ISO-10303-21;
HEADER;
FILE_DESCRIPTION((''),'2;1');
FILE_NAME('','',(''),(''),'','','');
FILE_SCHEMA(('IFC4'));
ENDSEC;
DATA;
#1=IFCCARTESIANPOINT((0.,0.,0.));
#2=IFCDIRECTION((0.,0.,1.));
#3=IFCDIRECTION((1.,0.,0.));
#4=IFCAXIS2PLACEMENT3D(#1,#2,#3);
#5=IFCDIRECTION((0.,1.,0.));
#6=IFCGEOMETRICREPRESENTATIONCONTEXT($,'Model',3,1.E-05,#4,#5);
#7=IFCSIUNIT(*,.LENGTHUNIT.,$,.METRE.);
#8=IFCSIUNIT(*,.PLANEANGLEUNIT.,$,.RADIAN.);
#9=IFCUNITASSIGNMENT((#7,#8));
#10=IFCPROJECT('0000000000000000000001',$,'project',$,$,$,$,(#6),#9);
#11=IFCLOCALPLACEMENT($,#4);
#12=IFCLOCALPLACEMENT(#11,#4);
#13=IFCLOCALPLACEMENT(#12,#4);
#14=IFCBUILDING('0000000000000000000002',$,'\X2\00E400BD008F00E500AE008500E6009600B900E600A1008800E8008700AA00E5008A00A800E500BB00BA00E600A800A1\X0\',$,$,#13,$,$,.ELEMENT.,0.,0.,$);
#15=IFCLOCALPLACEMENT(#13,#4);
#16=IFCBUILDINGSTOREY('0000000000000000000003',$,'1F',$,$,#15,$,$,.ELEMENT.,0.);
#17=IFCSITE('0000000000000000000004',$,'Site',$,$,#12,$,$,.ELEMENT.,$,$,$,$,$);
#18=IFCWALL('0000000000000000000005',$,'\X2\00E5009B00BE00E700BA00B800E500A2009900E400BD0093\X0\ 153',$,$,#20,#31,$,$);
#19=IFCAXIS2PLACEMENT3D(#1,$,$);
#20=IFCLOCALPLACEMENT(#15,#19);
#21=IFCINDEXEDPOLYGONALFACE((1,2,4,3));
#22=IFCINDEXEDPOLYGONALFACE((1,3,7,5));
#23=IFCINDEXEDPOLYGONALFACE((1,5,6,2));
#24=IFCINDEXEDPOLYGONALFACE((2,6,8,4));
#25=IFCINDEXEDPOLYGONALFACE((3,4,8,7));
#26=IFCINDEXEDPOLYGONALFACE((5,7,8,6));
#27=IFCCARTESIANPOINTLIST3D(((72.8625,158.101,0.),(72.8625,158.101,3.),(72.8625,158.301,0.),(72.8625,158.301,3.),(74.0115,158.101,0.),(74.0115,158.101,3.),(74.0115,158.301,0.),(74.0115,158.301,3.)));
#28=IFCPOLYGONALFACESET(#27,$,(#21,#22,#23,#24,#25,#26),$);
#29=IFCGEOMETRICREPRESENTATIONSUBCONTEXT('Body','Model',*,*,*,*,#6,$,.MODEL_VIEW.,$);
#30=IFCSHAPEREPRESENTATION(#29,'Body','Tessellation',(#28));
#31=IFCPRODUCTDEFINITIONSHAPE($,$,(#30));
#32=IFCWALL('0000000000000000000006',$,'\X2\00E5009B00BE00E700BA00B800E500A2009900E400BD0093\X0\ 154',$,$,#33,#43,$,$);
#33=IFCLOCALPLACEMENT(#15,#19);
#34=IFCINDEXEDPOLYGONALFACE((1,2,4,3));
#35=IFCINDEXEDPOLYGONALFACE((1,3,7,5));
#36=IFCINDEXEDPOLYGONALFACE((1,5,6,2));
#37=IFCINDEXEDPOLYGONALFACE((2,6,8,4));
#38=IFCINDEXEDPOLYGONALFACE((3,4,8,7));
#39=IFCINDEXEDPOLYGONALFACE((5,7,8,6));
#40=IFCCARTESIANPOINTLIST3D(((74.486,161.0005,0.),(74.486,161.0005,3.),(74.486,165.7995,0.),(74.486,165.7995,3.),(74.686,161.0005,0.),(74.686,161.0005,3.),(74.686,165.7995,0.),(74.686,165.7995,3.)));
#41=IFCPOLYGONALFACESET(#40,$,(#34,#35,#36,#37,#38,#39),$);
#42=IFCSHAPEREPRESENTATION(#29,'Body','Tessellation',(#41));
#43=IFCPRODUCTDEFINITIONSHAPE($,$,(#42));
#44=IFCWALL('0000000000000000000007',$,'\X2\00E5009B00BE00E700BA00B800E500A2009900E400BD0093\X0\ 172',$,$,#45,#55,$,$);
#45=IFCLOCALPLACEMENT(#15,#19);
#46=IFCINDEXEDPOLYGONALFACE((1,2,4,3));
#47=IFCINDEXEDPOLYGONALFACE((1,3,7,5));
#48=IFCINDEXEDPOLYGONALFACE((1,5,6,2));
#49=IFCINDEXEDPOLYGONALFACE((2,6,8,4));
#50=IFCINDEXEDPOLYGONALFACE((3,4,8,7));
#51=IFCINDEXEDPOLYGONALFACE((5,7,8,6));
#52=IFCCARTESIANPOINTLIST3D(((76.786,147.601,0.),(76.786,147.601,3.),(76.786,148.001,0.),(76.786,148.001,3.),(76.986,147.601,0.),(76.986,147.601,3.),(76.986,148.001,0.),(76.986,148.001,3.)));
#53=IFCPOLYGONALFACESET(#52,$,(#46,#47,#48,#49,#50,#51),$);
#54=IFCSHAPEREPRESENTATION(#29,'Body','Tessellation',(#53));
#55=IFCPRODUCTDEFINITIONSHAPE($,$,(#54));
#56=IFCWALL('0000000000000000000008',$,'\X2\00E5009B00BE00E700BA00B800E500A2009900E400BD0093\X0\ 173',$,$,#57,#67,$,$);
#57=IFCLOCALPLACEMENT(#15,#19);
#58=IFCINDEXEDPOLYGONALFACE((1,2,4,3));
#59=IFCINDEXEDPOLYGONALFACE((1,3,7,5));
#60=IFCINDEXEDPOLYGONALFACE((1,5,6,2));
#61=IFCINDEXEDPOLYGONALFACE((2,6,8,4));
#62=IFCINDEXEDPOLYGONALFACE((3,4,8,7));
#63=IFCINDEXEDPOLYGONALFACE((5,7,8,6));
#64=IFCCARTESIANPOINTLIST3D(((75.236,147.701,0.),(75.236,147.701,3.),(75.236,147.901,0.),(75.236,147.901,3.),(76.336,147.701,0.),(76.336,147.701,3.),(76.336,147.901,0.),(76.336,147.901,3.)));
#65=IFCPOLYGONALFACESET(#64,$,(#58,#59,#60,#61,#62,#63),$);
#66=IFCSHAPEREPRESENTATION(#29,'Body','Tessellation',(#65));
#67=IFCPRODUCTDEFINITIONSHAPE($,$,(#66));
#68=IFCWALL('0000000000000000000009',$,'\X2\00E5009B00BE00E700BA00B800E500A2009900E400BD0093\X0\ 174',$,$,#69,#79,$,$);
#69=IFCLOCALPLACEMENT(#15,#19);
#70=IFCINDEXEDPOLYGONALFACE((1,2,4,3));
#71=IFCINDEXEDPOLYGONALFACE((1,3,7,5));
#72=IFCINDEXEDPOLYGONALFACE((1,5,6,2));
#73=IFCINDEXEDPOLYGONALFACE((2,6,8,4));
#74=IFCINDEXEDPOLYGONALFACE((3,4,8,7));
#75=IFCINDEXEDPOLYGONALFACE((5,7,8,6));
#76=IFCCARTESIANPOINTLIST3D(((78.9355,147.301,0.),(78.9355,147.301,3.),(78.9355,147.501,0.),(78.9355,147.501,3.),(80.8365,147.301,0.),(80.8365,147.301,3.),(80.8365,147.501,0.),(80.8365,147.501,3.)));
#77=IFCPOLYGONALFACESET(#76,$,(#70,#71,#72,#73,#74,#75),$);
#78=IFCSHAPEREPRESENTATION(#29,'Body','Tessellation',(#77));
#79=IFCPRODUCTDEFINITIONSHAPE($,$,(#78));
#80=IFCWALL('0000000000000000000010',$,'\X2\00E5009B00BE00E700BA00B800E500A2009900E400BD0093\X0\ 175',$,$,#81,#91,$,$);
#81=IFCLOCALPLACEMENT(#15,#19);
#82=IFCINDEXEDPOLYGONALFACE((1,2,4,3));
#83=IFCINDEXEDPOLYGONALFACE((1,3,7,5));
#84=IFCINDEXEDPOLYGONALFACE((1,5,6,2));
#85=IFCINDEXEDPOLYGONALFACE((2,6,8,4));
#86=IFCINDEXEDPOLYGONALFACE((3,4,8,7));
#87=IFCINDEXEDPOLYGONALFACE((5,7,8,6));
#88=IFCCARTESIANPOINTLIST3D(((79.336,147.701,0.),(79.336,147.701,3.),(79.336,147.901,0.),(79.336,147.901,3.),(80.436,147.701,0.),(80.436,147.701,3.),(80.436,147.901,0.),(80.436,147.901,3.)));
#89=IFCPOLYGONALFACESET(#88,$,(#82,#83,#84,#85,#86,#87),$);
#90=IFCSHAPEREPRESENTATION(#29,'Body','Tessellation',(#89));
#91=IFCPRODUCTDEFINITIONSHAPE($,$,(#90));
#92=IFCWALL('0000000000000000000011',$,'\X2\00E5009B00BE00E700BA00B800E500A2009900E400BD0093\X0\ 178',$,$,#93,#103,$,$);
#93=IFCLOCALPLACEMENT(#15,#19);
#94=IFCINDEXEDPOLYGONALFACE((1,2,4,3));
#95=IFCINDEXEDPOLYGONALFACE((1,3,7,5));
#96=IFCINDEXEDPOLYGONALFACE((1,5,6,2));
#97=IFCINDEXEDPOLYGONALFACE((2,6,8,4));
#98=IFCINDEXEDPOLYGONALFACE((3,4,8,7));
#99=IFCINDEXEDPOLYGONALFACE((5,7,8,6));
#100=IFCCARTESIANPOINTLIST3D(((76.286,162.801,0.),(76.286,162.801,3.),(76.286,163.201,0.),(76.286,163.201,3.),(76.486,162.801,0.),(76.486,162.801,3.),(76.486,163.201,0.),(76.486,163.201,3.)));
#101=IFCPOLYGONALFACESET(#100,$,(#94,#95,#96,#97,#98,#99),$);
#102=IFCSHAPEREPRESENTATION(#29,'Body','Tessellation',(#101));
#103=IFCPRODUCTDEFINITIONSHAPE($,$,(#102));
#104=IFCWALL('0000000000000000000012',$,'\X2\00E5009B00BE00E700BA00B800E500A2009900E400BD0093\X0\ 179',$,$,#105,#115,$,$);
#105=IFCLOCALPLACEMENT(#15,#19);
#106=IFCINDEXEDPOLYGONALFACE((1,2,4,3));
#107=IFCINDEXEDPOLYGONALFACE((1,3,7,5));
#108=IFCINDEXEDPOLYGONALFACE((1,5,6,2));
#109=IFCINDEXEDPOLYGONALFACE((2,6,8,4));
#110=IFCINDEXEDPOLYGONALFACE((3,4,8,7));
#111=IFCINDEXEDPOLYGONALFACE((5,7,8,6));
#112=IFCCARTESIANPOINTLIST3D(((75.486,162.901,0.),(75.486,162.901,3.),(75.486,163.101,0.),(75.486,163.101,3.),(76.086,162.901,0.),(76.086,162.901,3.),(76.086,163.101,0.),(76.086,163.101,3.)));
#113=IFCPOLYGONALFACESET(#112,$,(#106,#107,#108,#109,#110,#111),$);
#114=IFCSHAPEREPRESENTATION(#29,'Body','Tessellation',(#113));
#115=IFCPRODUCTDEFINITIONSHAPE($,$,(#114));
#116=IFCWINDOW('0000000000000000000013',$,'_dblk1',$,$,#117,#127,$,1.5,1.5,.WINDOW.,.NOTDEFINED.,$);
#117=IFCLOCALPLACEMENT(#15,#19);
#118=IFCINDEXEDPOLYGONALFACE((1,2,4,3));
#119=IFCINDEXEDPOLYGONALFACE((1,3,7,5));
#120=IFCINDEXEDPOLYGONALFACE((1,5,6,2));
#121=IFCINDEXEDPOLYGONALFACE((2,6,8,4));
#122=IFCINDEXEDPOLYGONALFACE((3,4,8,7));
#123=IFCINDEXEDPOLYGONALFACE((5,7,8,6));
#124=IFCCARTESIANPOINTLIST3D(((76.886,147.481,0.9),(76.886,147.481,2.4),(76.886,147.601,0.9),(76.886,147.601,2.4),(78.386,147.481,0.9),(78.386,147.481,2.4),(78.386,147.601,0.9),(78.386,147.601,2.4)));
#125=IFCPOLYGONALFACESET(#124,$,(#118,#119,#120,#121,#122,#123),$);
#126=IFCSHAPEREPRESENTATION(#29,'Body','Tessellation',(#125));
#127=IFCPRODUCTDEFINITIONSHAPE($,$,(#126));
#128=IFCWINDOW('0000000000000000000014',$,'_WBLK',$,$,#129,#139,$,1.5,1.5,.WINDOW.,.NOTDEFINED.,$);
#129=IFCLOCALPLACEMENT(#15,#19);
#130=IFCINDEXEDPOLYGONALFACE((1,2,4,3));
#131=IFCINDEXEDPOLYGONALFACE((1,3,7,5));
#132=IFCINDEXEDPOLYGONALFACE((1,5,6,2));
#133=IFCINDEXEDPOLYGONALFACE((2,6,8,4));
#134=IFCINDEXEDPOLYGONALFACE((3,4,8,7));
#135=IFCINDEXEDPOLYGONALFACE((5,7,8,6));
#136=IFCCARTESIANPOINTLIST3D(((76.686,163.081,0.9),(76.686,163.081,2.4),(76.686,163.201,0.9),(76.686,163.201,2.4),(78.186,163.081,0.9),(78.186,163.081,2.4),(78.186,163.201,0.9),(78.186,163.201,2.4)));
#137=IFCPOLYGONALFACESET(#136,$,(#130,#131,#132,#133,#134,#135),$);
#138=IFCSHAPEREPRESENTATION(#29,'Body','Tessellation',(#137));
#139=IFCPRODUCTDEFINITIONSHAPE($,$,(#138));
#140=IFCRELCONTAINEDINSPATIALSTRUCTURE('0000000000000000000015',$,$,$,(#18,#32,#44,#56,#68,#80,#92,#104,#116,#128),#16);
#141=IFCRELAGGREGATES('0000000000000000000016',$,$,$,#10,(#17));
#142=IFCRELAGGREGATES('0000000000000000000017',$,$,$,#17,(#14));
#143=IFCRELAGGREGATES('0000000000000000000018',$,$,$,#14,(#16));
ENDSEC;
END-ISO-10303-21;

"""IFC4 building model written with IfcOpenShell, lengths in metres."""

from ifc_helpers import new_model, si_unit, direction, frame, frame_2d, origin_with_axes, place, context, subcontext, project, spatial, rectangle, extrude, element, save


model = new_model("IFC4")

# Units and contexts
model_context = context("Model", 3, precision=1e-05, world=origin_with_axes(), true_north=direction((0.0, 1.0, 0.0)))
body_context = subcontext(model_context, "Body", "Model", "MODEL_VIEW")
ifc_project = project(units=[si_unit("LENGTHUNIT", "METRE"), si_unit("PLANEANGLEUNIT", "RADIAN")], contexts=[model_context])

# Site, building, storey
placement = place(None, origin_with_axes())
site_placement = place(placement, origin_with_axes())
site = spatial("IfcSite", under=ifc_project, at=site_placement, Name="Site", CompositionType="ELEMENT")
building_placement = place(site_placement, origin_with_axes())
building = spatial("IfcBuilding", under=site, at=building_placement, Name="ä½\u008få®\u0085æ\u0096¹æ¡\u0088è\u0087ªå\u008a¨å»ºæ¨¡", CompositionType="ELEMENT", ElevationOfRefHeight=0.0, ElevationOfTerrain=0.0)
storey_placement = place(building_placement, origin_with_axes())
storey = spatial("IfcBuildingStorey", under=building, at=storey_placement, Name="1F", CompositionType="ELEMENT", Elevation=0.0)

# Walls
for number, where, z_axis, x_axis, name in (
    (1, (73.437, 158.201, 0.0), (0.0, 0.0, 1.0), (1.0, 0.0, 0.0), "å\u009b¾çº¸å¢\u0099ä½\u0093 153"),
):
    element("IfcWall", number, at=place(storey_placement, frame(where, z_axis=z_axis, x_axis=x_axis)), inside=storey, Name=name, context=body_context, shape_type="SweptSolid", body=[
        extrude(rectangle(XDim=1.149, YDim=0.2, at=frame_2d((0.0, 0.0), x_axis=(1.0, 0.0, 0.0))), frame((0.0, 0.0, 0.0), z_axis=(0.0, 0.0, 1.0)), (0.0, 0.0, 1.0), 3.0),
    ])
wall_1_placement = place(storey_placement, frame((74.586, 163.4, 0.0), z_axis=(0.0, 0.0, 1.0), x_axis=(0.0, -1.0, 0.0)))
element("IfcWall", 2, at=wall_1_placement, inside=storey, Name="å\u009b¾çº¸å¢\u0099ä½\u0093 154", context=body_context, shape_type="SweptSolid", body=[
    extrude(rectangle(XDim=4.799, YDim=0.2, at=frame_2d((0.0, 0.0), x_axis=(1.0, 0.0, 0.0))), frame((0.0, 0.0, 0.0), z_axis=(0.0, 0.0, 1.0)), (0.0, 0.0, 1.0), 3.0),
])
wall_2_placement = place(storey_placement, frame((76.886, 147.801, 0.0), z_axis=(0.0, 0.0, 1.0), x_axis=(0.0, -1.0, 0.0)))
element("IfcWall", 3, at=wall_2_placement, inside=storey, Name="å\u009b¾çº¸å¢\u0099ä½\u0093 172", context=body_context, shape_type="SweptSolid", body=[
    extrude(rectangle(XDim=0.4, YDim=0.2, at=frame_2d((0.0, 0.0), x_axis=(1.0, 0.0, 0.0))), frame((0.0, 0.0, 0.0), z_axis=(0.0, 0.0, 1.0)), (0.0, 0.0, 1.0), 3.0),
])
wall_3_placement = place(storey_placement, frame((75.786, 147.801, 0.0), z_axis=(0.0, 0.0, 1.0), x_axis=(1.0, 0.0, 0.0)))
element("IfcWall", 4, at=wall_3_placement, inside=storey, Name="å\u009b¾çº¸å¢\u0099ä½\u0093 173", context=body_context, shape_type="SweptSolid", body=[
    extrude(rectangle(XDim=1.1, YDim=0.2, at=frame_2d((0.0, 0.0), x_axis=(1.0, 0.0, 0.0))), frame((0.0, 0.0, 0.0), z_axis=(0.0, 0.0, 1.0)), (0.0, 0.0, 1.0), 3.0),
])
wall_4_placement = place(storey_placement, frame((79.886, 147.401, 0.0), z_axis=(0.0, 0.0, 1.0), x_axis=(1.0, 0.0, 0.0)))
element("IfcWall", 5, at=wall_4_placement, inside=storey, Name="å\u009b¾çº¸å¢\u0099ä½\u0093 174", context=body_context, shape_type="SweptSolid", body=[
    extrude(rectangle(XDim=1.901, YDim=0.2, at=frame_2d((0.0, 0.0), x_axis=(1.0, 0.0, 0.0))), frame((0.0, 0.0, 0.0), z_axis=(0.0, 0.0, 1.0)), (0.0, 0.0, 1.0), 3.0),
])
wall_5_placement = place(storey_placement, frame((79.886, 147.801, 0.0), z_axis=(0.0, 0.0, 1.0), x_axis=(1.0, 0.0, 0.0)))
element("IfcWall", 6, at=wall_5_placement, inside=storey, Name="å\u009b¾çº¸å¢\u0099ä½\u0093 175", context=body_context, shape_type="SweptSolid", body=[
    extrude(rectangle(XDim=1.1, YDim=0.2, at=frame_2d((0.0, 0.0), x_axis=(1.0, 0.0, 0.0))), frame((0.0, 0.0, 0.0), z_axis=(0.0, 0.0, 1.0)), (0.0, 0.0, 1.0), 3.0),
])
wall_6_placement = place(storey_placement, frame((76.386, 163.001, 0.0), z_axis=(0.0, 0.0, 1.0), x_axis=(0.0, 1.0, 0.0)))
element("IfcWall", 7, at=wall_6_placement, inside=storey, Name="å\u009b¾çº¸å¢\u0099ä½\u0093 178", context=body_context, shape_type="SweptSolid", body=[
    extrude(rectangle(XDim=0.4, YDim=0.2, at=frame_2d((0.0, 0.0), x_axis=(1.0, 0.0, 0.0))), frame((0.0, 0.0, 0.0), z_axis=(0.0, 0.0, 1.0)), (0.0, 0.0, 1.0), 3.0),
])
wall_7_placement = place(storey_placement, frame((75.786, 163.001, 0.0), z_axis=(0.0, 0.0, 1.0), x_axis=(1.0, 0.0, 0.0)))
element("IfcWall", 8, at=wall_7_placement, inside=storey, Name="å\u009b¾çº¸å¢\u0099ä½\u0093 179", context=body_context, shape_type="SweptSolid", body=[
    extrude(rectangle(XDim=0.6, YDim=0.2, at=frame_2d((0.0, 0.0), x_axis=(1.0, 0.0, 0.0))), frame((0.0, 0.0, 0.0), z_axis=(0.0, 0.0, 1.0)), (0.0, 0.0, 1.0), 3.0),
])

# Windows
for number, where, z_axis, x_axis, name in (
    (9, (77.636, 147.541, 0.9), (0.0, 0.0, 1.0), (1.0, 0.0, 0.0), "_dblk1"),
    (10, (77.436, 163.141, 0.9), (0.0, 0.0, 1.0), (1.0, 0.0, 0.0), "_WBLK"),
):
    element("IfcWindow", number, at=place(storey_placement, frame(where, z_axis=z_axis, x_axis=x_axis)), inside=storey, Name=name, OverallHeight=1.5, OverallWidth=1.5, PartitioningType="NOTDEFINED", PredefinedType="WINDOW", context=body_context, shape_type="SweptSolid", body=[
        extrude(rectangle(XDim=1.5, YDim=0.12, at=frame_2d((0.0, 0.0), x_axis=(1.0, 0.0, 0.0))), frame((0.0, 0.0, 0.0), z_axis=(0.0, 0.0, 1.0)), (0.0, 0.0, 1.0), 1.5),
    ])

save(model, "model.ifc")
